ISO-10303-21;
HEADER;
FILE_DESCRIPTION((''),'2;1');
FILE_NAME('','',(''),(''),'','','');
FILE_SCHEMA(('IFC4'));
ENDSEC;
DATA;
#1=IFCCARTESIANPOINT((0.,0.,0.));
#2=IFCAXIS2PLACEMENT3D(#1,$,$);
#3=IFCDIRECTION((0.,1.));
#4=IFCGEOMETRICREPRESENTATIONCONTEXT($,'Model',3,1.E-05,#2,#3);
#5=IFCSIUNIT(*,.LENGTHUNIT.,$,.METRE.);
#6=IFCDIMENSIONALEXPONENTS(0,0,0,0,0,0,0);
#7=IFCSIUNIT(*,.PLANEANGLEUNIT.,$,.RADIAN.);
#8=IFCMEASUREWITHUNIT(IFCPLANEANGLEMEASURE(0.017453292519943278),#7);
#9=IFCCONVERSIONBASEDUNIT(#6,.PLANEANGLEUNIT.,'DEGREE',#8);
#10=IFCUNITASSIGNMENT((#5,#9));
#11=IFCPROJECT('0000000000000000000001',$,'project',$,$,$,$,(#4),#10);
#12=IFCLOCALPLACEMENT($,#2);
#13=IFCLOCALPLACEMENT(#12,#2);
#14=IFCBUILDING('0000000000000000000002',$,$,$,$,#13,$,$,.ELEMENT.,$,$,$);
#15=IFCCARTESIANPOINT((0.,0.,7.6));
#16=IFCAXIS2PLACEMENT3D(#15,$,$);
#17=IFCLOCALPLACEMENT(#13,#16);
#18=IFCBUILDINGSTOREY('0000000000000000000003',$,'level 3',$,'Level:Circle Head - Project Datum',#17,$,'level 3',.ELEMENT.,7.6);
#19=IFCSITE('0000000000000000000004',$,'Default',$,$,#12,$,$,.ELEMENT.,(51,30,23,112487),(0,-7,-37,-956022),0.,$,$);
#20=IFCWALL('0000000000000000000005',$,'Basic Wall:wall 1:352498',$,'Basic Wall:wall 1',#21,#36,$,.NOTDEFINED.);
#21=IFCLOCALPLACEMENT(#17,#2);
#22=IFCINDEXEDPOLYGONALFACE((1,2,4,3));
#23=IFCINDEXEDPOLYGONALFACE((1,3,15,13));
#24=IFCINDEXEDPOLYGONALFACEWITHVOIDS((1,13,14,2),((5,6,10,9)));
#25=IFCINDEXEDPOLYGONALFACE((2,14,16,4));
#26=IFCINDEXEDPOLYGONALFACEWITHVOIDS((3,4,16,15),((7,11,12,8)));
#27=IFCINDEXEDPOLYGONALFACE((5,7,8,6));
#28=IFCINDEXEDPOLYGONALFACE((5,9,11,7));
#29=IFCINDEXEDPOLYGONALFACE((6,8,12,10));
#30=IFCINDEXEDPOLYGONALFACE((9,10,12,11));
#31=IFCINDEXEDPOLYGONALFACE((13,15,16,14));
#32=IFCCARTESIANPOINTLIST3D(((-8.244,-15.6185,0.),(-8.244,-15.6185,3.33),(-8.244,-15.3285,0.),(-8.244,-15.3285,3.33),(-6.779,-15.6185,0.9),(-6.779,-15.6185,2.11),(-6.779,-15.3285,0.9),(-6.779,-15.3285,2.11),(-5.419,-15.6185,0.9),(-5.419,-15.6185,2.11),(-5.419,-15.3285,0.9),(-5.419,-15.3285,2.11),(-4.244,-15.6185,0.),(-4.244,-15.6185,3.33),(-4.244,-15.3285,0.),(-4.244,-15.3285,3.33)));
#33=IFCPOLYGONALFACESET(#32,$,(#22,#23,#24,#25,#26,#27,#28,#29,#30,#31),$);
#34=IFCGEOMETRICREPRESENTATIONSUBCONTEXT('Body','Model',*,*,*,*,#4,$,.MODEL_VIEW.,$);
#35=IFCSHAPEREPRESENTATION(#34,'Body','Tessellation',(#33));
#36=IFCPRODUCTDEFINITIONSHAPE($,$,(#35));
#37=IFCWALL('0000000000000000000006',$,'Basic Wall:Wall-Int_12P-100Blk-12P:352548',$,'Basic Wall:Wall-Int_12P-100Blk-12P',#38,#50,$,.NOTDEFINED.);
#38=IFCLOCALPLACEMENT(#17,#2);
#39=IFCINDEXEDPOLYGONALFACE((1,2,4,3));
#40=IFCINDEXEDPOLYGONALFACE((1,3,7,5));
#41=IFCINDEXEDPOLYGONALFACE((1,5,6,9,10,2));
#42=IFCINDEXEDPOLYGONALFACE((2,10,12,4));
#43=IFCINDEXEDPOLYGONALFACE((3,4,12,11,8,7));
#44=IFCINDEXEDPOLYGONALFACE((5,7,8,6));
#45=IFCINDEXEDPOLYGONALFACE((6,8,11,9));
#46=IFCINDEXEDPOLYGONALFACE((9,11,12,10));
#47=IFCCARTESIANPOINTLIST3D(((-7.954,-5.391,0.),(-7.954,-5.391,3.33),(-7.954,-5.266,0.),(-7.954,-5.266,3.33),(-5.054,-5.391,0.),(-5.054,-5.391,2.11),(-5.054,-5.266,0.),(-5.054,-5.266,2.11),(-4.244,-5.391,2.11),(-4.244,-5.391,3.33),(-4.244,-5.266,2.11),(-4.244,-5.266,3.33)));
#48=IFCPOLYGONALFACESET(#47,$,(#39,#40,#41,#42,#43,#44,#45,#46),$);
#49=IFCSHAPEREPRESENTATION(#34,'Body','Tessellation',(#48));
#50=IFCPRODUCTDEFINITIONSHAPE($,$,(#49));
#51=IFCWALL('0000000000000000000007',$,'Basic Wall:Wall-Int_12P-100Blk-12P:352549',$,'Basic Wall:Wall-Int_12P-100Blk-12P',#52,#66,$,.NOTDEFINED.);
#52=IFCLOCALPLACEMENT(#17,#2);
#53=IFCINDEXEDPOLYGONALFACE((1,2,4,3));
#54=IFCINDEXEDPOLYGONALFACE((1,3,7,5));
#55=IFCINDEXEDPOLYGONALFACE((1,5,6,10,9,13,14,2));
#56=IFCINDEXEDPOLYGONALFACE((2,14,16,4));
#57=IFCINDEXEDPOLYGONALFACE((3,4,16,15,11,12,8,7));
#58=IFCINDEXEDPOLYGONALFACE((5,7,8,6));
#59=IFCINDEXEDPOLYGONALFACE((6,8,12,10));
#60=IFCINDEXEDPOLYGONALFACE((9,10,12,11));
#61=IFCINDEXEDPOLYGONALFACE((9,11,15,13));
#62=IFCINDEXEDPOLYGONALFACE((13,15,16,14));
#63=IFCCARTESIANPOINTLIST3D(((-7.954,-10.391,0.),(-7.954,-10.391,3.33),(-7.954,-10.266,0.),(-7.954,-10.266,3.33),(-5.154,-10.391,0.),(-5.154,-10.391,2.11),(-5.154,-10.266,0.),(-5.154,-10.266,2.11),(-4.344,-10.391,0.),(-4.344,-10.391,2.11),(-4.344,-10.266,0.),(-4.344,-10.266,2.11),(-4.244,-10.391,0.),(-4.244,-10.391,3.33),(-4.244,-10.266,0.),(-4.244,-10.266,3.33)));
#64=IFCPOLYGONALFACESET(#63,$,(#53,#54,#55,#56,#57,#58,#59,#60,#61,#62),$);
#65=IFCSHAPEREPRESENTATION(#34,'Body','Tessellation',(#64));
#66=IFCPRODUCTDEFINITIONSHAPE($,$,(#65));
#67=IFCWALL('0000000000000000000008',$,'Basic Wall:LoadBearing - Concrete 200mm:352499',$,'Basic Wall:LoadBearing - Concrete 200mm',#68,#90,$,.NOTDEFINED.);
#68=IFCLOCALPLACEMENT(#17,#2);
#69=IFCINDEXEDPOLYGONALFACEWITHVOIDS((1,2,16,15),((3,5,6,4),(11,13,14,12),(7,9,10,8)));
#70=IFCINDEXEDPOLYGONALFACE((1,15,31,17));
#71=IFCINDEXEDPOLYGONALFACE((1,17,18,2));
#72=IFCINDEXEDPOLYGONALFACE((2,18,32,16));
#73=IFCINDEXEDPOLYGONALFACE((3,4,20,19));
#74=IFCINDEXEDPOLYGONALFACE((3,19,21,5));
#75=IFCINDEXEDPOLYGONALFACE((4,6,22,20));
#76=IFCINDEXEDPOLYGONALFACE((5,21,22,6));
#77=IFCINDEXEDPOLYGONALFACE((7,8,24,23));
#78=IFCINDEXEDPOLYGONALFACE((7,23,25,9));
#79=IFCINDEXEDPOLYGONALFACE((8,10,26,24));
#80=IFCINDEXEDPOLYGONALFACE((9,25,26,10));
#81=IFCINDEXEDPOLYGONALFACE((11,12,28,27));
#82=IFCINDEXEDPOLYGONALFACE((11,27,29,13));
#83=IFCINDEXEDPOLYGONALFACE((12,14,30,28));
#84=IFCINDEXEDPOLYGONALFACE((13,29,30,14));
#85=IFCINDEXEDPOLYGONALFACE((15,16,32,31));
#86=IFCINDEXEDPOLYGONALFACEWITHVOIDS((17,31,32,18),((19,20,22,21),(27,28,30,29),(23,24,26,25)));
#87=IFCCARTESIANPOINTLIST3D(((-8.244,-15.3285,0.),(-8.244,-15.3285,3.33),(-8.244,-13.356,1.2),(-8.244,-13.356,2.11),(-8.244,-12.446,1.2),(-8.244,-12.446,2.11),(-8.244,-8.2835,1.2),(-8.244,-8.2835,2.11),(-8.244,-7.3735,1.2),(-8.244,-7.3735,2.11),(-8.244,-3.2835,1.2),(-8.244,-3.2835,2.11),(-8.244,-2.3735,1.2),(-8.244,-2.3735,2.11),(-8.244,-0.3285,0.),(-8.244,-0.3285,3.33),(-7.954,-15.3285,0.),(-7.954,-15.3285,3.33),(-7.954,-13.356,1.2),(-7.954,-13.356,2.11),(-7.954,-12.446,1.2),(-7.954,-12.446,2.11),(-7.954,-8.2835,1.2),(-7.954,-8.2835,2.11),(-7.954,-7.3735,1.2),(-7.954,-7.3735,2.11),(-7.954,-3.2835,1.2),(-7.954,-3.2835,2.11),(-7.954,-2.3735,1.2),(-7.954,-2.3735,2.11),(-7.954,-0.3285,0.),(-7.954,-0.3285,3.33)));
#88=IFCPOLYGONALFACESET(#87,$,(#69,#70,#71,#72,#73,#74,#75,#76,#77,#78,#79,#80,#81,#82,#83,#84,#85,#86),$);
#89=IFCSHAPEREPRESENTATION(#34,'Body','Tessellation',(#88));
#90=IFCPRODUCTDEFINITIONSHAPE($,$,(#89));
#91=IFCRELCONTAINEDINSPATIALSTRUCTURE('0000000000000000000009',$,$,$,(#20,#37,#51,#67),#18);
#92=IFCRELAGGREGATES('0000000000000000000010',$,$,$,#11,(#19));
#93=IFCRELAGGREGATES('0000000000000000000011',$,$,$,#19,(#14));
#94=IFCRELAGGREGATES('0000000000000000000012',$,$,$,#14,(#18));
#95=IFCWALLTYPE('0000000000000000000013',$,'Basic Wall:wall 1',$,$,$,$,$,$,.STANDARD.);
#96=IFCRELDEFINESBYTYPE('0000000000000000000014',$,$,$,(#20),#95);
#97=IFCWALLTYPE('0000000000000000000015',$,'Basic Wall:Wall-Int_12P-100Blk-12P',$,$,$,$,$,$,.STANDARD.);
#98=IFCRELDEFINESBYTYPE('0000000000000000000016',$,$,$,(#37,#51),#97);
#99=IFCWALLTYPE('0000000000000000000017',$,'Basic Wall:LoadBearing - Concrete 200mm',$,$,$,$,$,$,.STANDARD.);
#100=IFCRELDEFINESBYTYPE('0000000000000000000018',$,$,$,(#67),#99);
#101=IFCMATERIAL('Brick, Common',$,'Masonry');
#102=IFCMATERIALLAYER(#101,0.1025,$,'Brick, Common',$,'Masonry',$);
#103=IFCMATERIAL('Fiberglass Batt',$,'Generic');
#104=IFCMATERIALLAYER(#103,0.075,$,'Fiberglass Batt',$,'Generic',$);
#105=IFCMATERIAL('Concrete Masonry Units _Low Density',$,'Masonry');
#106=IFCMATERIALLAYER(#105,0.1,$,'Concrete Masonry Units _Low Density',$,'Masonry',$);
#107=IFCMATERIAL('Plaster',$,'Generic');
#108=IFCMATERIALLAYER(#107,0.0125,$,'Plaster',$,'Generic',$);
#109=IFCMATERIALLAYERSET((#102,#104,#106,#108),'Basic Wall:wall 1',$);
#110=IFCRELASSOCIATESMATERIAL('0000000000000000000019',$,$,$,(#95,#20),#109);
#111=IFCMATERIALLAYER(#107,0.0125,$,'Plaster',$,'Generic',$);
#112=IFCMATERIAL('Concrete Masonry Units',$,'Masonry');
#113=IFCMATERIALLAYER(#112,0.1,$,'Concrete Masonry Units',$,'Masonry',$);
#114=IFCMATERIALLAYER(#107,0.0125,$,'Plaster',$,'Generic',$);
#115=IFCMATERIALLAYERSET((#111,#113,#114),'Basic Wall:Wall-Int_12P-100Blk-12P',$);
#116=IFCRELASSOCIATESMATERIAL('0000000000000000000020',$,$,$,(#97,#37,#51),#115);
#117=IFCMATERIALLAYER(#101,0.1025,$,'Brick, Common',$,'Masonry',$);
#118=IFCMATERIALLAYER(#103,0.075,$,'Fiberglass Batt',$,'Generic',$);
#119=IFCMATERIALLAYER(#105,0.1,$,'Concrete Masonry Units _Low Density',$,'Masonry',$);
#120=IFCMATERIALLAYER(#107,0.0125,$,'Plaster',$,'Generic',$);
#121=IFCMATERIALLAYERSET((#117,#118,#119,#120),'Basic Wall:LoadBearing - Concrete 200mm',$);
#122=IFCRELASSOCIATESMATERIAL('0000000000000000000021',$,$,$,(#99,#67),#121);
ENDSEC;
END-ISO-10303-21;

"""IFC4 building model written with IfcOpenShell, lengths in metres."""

from ifc_helpers import new_model, entity, si_unit, converted_unit, direction, frame, frame_2d, origin, place, context, subcontext, project, spatial, polyline, rectangle, extrude, clip, bounded_halfspace, material, layer, layer_set, layer_usage, type_object, element, save


model = new_model("IFC4")

# Units and contexts
model_context = context("Model", 3, precision=1e-05, world=origin(), true_north=direction((0.0, 1.0)))
body_context = subcontext(model_context, "Body", "Model", "MODEL_VIEW")
ifc_project = project(units=[si_unit("LENGTHUNIT", "METRE"), converted_unit("PLANEANGLEUNIT", "DEGREE", entity("IfcPlaneAngleMeasure", 0.017453292519943278), si_unit("PLANEANGLEUNIT", "RADIAN"), dimensions=[0, 0, 0, 0, 0, 0, 0])], contexts=[model_context])

# Site, building, storey
site_placement = place(None, origin())
site = spatial("IfcSite", under=ifc_project, at=site_placement, Name="Default", CompositionType="ELEMENT", RefLatitude=(51, 30, 23, 112487), RefLongitude=(0, -7, -37, -956022), RefElevation=0.0)
building_placement = place(site_placement, origin())
building = spatial("IfcBuilding", under=site, at=building_placement, CompositionType="ELEMENT")
storey_placement = place(building_placement, frame((0.0, 0.0, 7.6)))
storey = spatial("IfcBuildingStorey", under=building, at=storey_placement, Name="level 3", ObjectType="Level:Circle Head - Project Datum", LongName="level 3", CompositionType="ELEMENT", Elevation=7.6)

# Walls, openings
ifc_material_1 = material(Name="Brick, Common", Category="Masonry")
ifc_layer_1 = layer(ifc_material_1, 0.1025, Name="Brick, Common", Category="Masonry")
ifc_material_2 = material(Name="Fiberglass Batt", Category="Generic")
ifc_layer_2 = layer(ifc_material_2, 0.075, Name="Fiberglass Batt", Category="Generic")
ifc_material_3 = material(Name="Concrete Masonry Units _Low Density", Category="Masonry")
ifc_layer_3 = layer(ifc_material_3, 0.1, Name="Concrete Masonry Units _Low Density", Category="Masonry")
ifc_material_4 = material(Name="Plaster", Category="Generic")
ifc_layer_4 = layer(ifc_material_4, 0.0125, Name="Plaster", Category="Generic")
ifc_layer_set_1 = layer_set([ifc_layer_1, ifc_layer_2, ifc_layer_3, ifc_layer_4], Name="Basic Wall:wall 1")
ifc_layer_usage_1 = layer_usage(ifc_layer_set_1, "AXIS2", "NEGATIVE", 0.145)
wall_type_1 = type_object("IfcWallType", Name="Basic Wall:wall 1", PredefinedType="STANDARD", material=ifc_layer_set_1)
wall_1_placement = place(storey_placement, frame((-4.244, -15.4735, 0.0), z_axis=(0.0, 0.0, 1.0), x_axis=(-1.0, 0.0, 0.0)))
wall_1 = element("IfcWall", 1, at=wall_1_placement, inside=storey, type_object=wall_type_1, material=ifc_layer_usage_1, Name="Basic Wall:wall 1:352498", ObjectType="Basic Wall:wall 1", PredefinedType="NOTDEFINED", context=body_context, shape_type="Clipping", body=[
    clip(extrude(rectangle(XDim=4.0, YDim=0.29, at=frame_2d((2.0, 0.0), x_axis=(-1.0, 0.0))), origin(), (0.0, 0.0, 1.0), 3.33), bounded_halfspace(frame((0.0, -0.145, 3.33), z_axis=(0.0, 0.0, -1.0), x_axis=(0.0, -1.0, 0.0)), True, frame((0.0, -0.145, 3.33)), polyline([(0.0, 0.0), (3.71, 0.0), (4.0, 0.0), (4.0, 0.29), (0.0, 0.29), (0.0, 0.0)]))),
])
opening_1_placement = place(wall_1_placement, frame((1.175, -0.145, 0.9)))
element("IfcOpeningElement", 2, at=opening_1_placement, cuts=wall_1, PredefinedType="OPENING", context=body_context, shape_type="SweptSolid", body=[
    extrude(rectangle(XDim=1.21, YDim=1.36, at=frame_2d((0.605, 0.68), x_axis=(-1.0, 0.0))), frame((0.0, 0.0, 0.0), z_axis=(0.0, 1.0, 0.0), x_axis=(0.0, 0.0, 1.0)), (0.0, 0.0, 1.0), 0.29),
])
ifc_layer_5 = layer(ifc_material_4, 0.0125, Name="Plaster", Category="Generic")
ifc_material_5 = material(Name="Concrete Masonry Units", Category="Masonry")
ifc_layer_6 = layer(ifc_material_5, 0.1, Name="Concrete Masonry Units", Category="Masonry")
ifc_layer_7 = layer(ifc_material_4, 0.0125, Name="Plaster", Category="Generic")
ifc_layer_set_2 = layer_set([ifc_layer_5, ifc_layer_6, ifc_layer_7], Name="Basic Wall:Wall-Int_12P-100Blk-12P")
ifc_layer_usage_2 = layer_usage(ifc_layer_set_2, "AXIS2", "NEGATIVE", 0.0625)
wall_type_2 = type_object("IfcWallType", Name="Basic Wall:Wall-Int_12P-100Blk-12P", PredefinedType="STANDARD", material=ifc_layer_set_2)
wall_2_placement = place(storey_placement, frame((-7.954, -5.3285, 0.0)))
wall_2 = element("IfcWall", 3, at=wall_2_placement, inside=storey, type_object=wall_type_2, material=ifc_layer_usage_2, Name="Basic Wall:Wall-Int_12P-100Blk-12P:352548", ObjectType="Basic Wall:Wall-Int_12P-100Blk-12P", PredefinedType="NOTDEFINED", context=body_context, shape_type="Clipping", body=[
    clip(extrude(rectangle(XDim=3.71, YDim=0.125, at=frame_2d((1.855, 0.0), x_axis=(-1.0, 0.0))), origin(), (0.0, 0.0, 1.0), 3.33), bounded_halfspace(frame((0.0, -0.0625, 3.33), z_axis=(0.0, 0.0, -1.0), x_axis=(0.0, 1.0, 0.0)), True, frame((0.0, -0.0625, 3.33)), polyline([(0.0, 0.0), (3.71, 0.0), (3.71, 0.125), (0.0, 0.125), (0.0, 0.0)]))),
])
opening_2_placement = place(wall_2_placement, frame((3.71, 0.0625, 0.0)))
element("IfcOpeningElement", 4, at=opening_2_placement, cuts=wall_2, PredefinedType="OPENING", context=body_context, shape_type="SweptSolid", body=[
    extrude(rectangle(XDim=2.11, YDim=0.81, at=frame_2d((1.055, 0.405), x_axis=(1.0, 0.0))), frame((0.0, 0.0, 0.0), z_axis=(0.0, -1.0, 0.0), x_axis=(0.0, 0.0, 1.0)), (0.0, 0.0, 1.0), 0.125),
])
ifc_layer_usage_3 = layer_usage(ifc_layer_set_2, "AXIS2", "NEGATIVE", 0.0625)
wall_3_placement = place(storey_placement, frame((-7.954, -10.3285, 0.0)))
wall_3 = element("IfcWall", 5, at=wall_3_placement, inside=storey, type_object=wall_type_2, material=ifc_layer_usage_3, Name="Basic Wall:Wall-Int_12P-100Blk-12P:352549", ObjectType="Basic Wall:Wall-Int_12P-100Blk-12P", PredefinedType="NOTDEFINED", context=body_context, shape_type="Clipping", body=[
    clip(extrude(rectangle(XDim=3.71, YDim=0.125, at=frame_2d((1.855, 0.0), x_axis=(-1.0, 0.0))), origin(), (0.0, 0.0, 1.0), 3.33), bounded_halfspace(frame((0.0, -0.0625, 3.33), z_axis=(0.0, 0.0, -1.0), x_axis=(0.0, 1.0, 0.0)), True, frame((0.0, -0.0625, 3.33)), polyline([(0.0, 0.0), (3.71, 0.0), (3.71, 0.125), (0.0, 0.125), (0.0, 0.0)]))),
])
opening_3_placement = place(wall_3_placement, frame((3.61, 0.0625, 0.0)))
element("IfcOpeningElement", 6, at=opening_3_placement, cuts=wall_3, PredefinedType="OPENING", context=body_context, shape_type="SweptSolid", body=[
    extrude(rectangle(XDim=2.11, YDim=0.81, at=frame_2d((1.055, 0.405), x_axis=(1.0, 0.0))), frame((0.0, 0.0, 0.0), z_axis=(0.0, -1.0, 0.0), x_axis=(0.0, 0.0, 1.0)), (0.0, 0.0, 1.0), 0.125),
])

# Wall, openings
ifc_layer_8 = layer(ifc_material_1, 0.1025, Name="Brick, Common", Category="Masonry")
ifc_layer_9 = layer(ifc_material_2, 0.075, Name="Fiberglass Batt", Category="Generic")
ifc_layer_10 = layer(ifc_material_3, 0.1, Name="Concrete Masonry Units _Low Density", Category="Masonry")
ifc_layer_11 = layer(ifc_material_4, 0.0125, Name="Plaster", Category="Generic")
ifc_layer_set_3 = layer_set([ifc_layer_8, ifc_layer_9, ifc_layer_10, ifc_layer_11], Name="Basic Wall:LoadBearing - Concrete 200mm")
ifc_layer_usage_4 = layer_usage(ifc_layer_set_3, "AXIS2", "NEGATIVE", 0.145)
wall_type_3 = type_object("IfcWallType", Name="Basic Wall:LoadBearing - Concrete 200mm", PredefinedType="STANDARD", material=ifc_layer_set_3)
wall_4_placement = place(storey_placement, frame((-8.099, -15.3285, 0.0), z_axis=(0.0, 0.0, 1.0), x_axis=(0.0, 1.0, 0.0)))
wall_4 = element("IfcWall", 7, at=wall_4_placement, inside=storey, type_object=wall_type_3, material=ifc_layer_usage_4, Name="Basic Wall:LoadBearing - Concrete 200mm:352499", ObjectType="Basic Wall:LoadBearing - Concrete 200mm", PredefinedType="NOTDEFINED", context=body_context, shape_type="Clipping", body=[
    clip(extrude(rectangle(XDim=15.0, YDim=0.29, at=frame_2d((7.5, 0.0), x_axis=(-1.0, 0.0))), origin(), (0.0, 0.0, 1.0), 3.33), bounded_halfspace(frame((0.0, -0.145, 3.33), z_axis=(0.0, 0.0, -1.0), x_axis=(1.0, 0.0, 0.0)), True, frame((0.0, -0.145, 3.33)), polyline([(0.0, 0.0), (4.9375, 0.0), (5.0625, 0.0), (9.9375, 0.0), (10.0625, 0.0), (15.0, 0.0), (15.0, 0.29), (0.0, 0.29), (0.0, 0.0)]))),
])
opening_4_placement = place(wall_4_placement, frame((1.9725, -0.145, 1.2)))
element("IfcOpeningElement", 8, at=opening_4_placement, cuts=wall_4, PredefinedType="OPENING", context=body_context, shape_type="SweptSolid", body=[
    extrude(rectangle(XDim=0.91, YDim=0.91, at=frame_2d((0.455, 0.455), x_axis=(-1.0, 0.0))), frame((0.0, 0.0, 0.0), z_axis=(0.0, 1.0, 0.0), x_axis=(0.0, 0.0, 1.0)), (0.0, 0.0, 1.0), 0.29),
])
opening_5_placement = place(wall_4_placement, frame((12.045, -0.145, 1.2)))
element("IfcOpeningElement", 9, at=opening_5_placement, cuts=wall_4, PredefinedType="OPENING", context=body_context, shape_type="SweptSolid", body=[
    extrude(rectangle(XDim=0.91, YDim=0.91, at=frame_2d((0.455, 0.455), x_axis=(-1.0, 0.0))), frame((0.0, 0.0, 0.0), z_axis=(0.0, 1.0, 0.0), x_axis=(0.0, 0.0, 1.0)), (0.0, 0.0, 1.0), 0.29),
])
opening_6_placement = place(wall_4_placement, frame((7.045, -0.145, 1.2)))
element("IfcOpeningElement", 10, at=opening_6_placement, cuts=wall_4, PredefinedType="OPENING", context=body_context, shape_type="SweptSolid", body=[
    extrude(rectangle(XDim=0.91, YDim=0.91, at=frame_2d((0.455, 0.455), x_axis=(-1.0, 0.0))), frame((0.0, 0.0, 0.0), z_axis=(0.0, 1.0, 0.0), x_axis=(0.0, 0.0, 1.0)), (0.0, 0.0, 1.0), 0.29),
])

save(model, "model.ifc")
